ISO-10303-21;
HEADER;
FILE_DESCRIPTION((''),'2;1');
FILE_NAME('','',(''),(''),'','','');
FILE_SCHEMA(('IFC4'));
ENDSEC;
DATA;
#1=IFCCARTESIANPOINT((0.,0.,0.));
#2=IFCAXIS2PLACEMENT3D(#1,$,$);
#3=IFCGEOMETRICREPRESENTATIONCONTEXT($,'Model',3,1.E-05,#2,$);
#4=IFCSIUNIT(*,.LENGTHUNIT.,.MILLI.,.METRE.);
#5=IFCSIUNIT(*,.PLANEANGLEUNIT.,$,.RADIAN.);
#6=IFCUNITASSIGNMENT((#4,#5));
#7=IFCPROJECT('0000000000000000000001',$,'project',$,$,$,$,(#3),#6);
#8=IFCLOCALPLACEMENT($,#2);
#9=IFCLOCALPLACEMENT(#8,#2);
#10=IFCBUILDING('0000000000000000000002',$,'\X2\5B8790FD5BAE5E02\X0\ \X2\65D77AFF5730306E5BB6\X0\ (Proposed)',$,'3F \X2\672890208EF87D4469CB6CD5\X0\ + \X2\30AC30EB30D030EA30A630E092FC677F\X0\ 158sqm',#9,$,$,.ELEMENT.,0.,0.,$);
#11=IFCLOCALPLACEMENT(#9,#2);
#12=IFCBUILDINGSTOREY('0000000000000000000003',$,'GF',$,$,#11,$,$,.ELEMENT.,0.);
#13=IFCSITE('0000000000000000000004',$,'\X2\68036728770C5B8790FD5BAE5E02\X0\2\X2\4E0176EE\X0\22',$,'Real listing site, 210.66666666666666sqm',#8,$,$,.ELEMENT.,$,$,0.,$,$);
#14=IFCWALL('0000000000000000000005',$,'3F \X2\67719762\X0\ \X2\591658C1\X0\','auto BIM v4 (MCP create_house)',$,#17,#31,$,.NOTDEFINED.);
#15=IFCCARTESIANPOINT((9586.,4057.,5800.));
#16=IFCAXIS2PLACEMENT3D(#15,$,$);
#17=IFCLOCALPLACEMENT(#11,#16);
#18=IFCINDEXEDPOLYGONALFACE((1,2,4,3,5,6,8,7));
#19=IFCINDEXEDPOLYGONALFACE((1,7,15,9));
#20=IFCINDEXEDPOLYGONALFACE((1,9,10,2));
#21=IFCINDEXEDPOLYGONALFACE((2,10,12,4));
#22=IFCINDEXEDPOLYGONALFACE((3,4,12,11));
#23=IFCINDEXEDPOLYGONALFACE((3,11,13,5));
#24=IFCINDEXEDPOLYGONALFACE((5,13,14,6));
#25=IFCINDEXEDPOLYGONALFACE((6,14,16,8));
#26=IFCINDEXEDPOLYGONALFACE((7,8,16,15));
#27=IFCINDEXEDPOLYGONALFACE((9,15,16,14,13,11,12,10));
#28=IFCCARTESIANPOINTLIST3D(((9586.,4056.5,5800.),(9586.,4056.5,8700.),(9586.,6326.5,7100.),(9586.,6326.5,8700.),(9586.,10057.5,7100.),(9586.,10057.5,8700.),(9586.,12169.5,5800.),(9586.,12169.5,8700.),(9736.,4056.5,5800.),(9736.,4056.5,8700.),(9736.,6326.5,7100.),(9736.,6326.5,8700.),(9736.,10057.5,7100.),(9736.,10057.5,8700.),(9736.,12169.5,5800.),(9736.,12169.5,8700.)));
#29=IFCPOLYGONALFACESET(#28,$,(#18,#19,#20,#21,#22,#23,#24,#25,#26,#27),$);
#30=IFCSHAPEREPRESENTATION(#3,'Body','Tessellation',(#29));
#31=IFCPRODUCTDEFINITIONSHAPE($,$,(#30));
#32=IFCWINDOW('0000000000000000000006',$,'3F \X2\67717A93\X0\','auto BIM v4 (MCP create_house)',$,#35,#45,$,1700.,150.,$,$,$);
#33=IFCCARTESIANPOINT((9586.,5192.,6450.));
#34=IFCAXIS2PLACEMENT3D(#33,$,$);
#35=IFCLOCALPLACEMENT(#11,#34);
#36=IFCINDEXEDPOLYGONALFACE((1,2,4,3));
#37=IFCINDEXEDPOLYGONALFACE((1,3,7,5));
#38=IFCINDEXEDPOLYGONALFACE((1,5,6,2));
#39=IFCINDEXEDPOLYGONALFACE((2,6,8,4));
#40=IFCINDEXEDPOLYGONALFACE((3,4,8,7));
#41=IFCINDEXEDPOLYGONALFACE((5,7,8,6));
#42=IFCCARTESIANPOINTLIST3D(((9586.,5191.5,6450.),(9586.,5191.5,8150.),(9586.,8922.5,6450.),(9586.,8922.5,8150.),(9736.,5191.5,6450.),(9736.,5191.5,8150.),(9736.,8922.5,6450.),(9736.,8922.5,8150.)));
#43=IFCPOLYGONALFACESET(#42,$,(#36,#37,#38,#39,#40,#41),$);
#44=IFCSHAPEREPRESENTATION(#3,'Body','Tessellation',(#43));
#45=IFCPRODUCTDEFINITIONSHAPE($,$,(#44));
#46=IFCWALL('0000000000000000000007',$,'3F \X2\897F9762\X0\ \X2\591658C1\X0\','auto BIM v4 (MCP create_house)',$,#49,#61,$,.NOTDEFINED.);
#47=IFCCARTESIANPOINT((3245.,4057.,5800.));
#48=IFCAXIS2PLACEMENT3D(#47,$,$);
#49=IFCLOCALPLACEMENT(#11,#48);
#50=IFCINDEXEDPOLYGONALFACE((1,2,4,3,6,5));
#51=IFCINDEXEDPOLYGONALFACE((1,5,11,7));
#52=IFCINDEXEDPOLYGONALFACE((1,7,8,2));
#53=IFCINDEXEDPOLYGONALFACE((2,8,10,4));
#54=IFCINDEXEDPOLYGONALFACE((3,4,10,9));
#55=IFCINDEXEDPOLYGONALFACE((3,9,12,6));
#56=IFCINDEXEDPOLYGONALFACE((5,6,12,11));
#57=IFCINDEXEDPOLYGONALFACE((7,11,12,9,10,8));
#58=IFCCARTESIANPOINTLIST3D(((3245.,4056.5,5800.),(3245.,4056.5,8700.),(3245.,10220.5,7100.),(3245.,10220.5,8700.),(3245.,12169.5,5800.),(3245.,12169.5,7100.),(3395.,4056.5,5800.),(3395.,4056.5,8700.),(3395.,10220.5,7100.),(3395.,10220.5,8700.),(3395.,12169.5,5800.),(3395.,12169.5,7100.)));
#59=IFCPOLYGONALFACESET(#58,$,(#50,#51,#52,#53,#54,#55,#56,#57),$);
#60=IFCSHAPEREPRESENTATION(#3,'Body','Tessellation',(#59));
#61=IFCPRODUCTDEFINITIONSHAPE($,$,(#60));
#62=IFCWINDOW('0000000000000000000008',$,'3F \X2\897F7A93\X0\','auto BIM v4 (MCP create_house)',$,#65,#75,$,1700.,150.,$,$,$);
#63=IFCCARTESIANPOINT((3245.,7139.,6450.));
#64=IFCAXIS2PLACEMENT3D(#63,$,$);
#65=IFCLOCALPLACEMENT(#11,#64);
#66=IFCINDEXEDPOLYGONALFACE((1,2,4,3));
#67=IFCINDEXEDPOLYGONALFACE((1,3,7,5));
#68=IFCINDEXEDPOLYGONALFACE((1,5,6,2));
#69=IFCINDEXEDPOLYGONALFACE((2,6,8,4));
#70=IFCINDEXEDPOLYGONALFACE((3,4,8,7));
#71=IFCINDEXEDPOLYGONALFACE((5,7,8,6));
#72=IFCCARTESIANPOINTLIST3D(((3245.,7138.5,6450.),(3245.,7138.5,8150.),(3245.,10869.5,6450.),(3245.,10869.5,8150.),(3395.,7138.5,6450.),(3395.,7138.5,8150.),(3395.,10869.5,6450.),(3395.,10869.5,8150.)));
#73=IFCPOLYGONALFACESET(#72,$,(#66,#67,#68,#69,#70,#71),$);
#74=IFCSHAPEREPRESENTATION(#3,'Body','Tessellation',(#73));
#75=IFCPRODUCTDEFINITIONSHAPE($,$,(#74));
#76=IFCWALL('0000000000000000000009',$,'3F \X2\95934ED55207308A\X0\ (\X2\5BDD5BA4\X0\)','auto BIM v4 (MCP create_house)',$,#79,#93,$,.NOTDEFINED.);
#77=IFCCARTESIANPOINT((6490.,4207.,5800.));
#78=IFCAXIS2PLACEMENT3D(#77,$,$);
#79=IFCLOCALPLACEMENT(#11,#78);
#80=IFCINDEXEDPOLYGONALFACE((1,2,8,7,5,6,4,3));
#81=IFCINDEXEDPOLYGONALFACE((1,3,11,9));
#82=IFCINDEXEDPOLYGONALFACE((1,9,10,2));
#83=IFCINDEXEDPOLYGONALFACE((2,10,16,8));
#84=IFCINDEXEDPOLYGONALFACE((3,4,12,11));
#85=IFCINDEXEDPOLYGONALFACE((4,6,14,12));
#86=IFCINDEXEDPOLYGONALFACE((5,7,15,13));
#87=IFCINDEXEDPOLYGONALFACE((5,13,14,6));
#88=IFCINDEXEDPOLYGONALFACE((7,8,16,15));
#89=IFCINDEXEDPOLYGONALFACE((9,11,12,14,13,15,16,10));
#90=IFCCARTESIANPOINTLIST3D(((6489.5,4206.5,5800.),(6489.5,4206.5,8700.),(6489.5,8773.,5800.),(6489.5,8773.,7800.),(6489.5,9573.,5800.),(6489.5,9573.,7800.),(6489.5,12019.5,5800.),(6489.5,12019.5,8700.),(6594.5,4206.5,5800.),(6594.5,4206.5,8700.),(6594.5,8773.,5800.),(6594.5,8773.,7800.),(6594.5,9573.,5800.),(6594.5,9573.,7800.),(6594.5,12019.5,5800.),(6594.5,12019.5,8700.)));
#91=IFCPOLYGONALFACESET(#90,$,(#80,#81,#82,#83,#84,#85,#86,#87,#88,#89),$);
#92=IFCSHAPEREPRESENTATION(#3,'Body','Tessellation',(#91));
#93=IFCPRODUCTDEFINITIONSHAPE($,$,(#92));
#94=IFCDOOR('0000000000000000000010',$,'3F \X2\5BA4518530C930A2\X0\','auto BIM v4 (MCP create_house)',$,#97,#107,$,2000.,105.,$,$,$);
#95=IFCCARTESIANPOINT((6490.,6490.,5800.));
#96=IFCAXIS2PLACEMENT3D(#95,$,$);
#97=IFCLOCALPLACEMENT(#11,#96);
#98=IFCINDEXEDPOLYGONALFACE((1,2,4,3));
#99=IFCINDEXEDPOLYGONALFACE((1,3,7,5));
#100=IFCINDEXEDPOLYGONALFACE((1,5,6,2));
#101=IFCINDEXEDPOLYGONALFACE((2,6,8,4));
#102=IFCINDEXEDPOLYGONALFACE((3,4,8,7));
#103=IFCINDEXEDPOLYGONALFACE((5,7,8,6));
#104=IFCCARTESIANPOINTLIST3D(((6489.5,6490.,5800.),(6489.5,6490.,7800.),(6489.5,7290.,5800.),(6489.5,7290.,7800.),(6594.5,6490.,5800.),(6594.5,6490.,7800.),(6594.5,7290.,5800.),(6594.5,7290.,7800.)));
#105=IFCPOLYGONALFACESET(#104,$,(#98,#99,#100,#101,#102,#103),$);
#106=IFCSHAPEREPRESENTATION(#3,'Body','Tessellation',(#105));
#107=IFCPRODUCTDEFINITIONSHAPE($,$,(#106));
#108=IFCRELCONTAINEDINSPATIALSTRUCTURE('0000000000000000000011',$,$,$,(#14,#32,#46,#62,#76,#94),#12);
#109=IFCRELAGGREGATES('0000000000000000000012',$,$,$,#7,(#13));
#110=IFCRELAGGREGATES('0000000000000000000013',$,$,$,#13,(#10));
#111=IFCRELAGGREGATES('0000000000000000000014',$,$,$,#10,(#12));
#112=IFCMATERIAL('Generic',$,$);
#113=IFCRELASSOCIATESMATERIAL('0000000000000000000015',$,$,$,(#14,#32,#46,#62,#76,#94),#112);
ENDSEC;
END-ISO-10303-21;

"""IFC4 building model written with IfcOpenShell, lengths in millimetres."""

from ifc_helpers import new_model, si_unit, frame, frame_2d, origin, place, context, project, spatial, rectangle, extrude, material, element, fill, save


model = new_model("IFC4")

# Units and contexts
model_context = context("Model", 3, precision=1e-05, world=origin())
ifc_project = project(units=[si_unit("LENGTHUNIT", "METRE", prefix="MILLI"), si_unit("PLANEANGLEUNIT", "RADIAN")], contexts=[model_context])

# Site, building, storey
site_placement = place(None, origin())
site = spatial("IfcSite", under=ifc_project, at=site_placement, Name="栃木県宇都宮市2丁目22", ObjectType="Real listing site, 210.66666666666666sqm", CompositionType="ELEMENT", RefElevation=0.0)
building_placement = place(site_placement, origin())
building = spatial("IfcBuilding", under=site, at=building_placement, Name="宇都宮市 旗竿地の家 (Proposed)", ObjectType="3F 木造軸組構法 + ガルバリウム鋼板 158sqm", CompositionType="ELEMENT", ElevationOfRefHeight=0.0, ElevationOfTerrain=0.0)
storey_placement = place(building_placement, origin())
storey = spatial("IfcBuildingStorey", under=building, at=storey_placement, Name="GF", CompositionType="ELEMENT", Elevation=0.0)

# Shared definitions
ifc_material = material(Name="Generic")

# Walls, openings, windows
wall_1_placement = place(storey_placement, frame((9586.0, 4057.0, 5800.0)))
wall_1 = element("IfcWall", 1, at=wall_1_placement, inside=storey, material=ifc_material, Name="3F 東面 外壁", Description="auto BIM v4 (MCP create_house)", PredefinedType="NOTDEFINED", context=model_context, shape_type="SweptSolid", body=[
    extrude(rectangle(XDim=150.0, YDim=8113.0, at=frame_2d((75.0, 4056.0))), frame((9586.0, 4057.0, 5800.0)), (0.0, 0.0, 1.0), 2900.0),
])
opening_1_placement = place(storey_placement, frame((9586.0, 5192.0, 6450.0)))
opening_1 = element("IfcOpeningElement", 2, at=opening_1_placement, cuts=wall_1, PredefinedType="NOTDEFINED", context=model_context, shape_type="SweptSolid", body=[
    extrude(rectangle(XDim=150.0, YDim=3731.0, at=frame_2d((75.0, 1865.0))), frame((9586.0, 5192.0, 6450.0)), (0.0, 0.0, 1.0), 1700.0),
])
window_1_placement = place(storey_placement, frame((9586.0, 5192.0, 6450.0)))
window_1 = element("IfcWindow", 3, at=window_1_placement, inside=storey, material=ifc_material, Name="3F 東窓", Description="auto BIM v4 (MCP create_house)", OverallHeight=1700.0, OverallWidth=150.0, context=model_context, shape_type="SweptSolid", body=[
    extrude(rectangle(XDim=150.0, YDim=3731.0, at=frame_2d((75.0, 1865.0))), frame((9586.0, 5192.0, 6450.0)), (0.0, 0.0, 1.0), 1700.0),
])
fill(opening_1, window_1)
wall_2_placement = place(storey_placement, frame((3245.0, 4057.0, 5800.0)))
wall_2 = element("IfcWall", 4, at=wall_2_placement, inside=storey, material=ifc_material, Name="3F 西面 外壁", Description="auto BIM v4 (MCP create_house)", PredefinedType="NOTDEFINED", context=model_context, shape_type="SweptSolid", body=[
    extrude(rectangle(XDim=150.0, YDim=8113.0, at=frame_2d((75.0, 4056.0))), frame((3245.0, 4057.0, 5800.0)), (0.0, 0.0, 1.0), 2900.0),
])
opening_2_placement = place(storey_placement, frame((3245.0, 7139.0, 6450.0)))
opening_2 = element("IfcOpeningElement", 5, at=opening_2_placement, cuts=wall_2, PredefinedType="NOTDEFINED", context=model_context, shape_type="SweptSolid", body=[
    extrude(rectangle(XDim=150.0, YDim=3731.0, at=frame_2d((75.0, 1865.0))), frame((3245.0, 7139.0, 6450.0)), (0.0, 0.0, 1.0), 1700.0),
])
window_2_placement = place(storey_placement, frame((3245.0, 7139.0, 6450.0)))
window_2 = element("IfcWindow", 6, at=window_2_placement, inside=storey, material=ifc_material, Name="3F 西窓", Description="auto BIM v4 (MCP create_house)", OverallHeight=1700.0, OverallWidth=150.0, context=model_context, shape_type="SweptSolid", body=[
    extrude(rectangle(XDim=150.0, YDim=3731.0, at=frame_2d((75.0, 1865.0))), frame((3245.0, 7139.0, 6450.0)), (0.0, 0.0, 1.0), 1700.0),
])
fill(opening_2, window_2)

# Wall, opening, door
wall_3_placement = place(storey_placement, frame((6490.0, 4207.0, 5800.0)))
wall_3 = element("IfcWall", 7, at=wall_3_placement, inside=storey, material=ifc_material, Name="3F 間仕切り (寝室)", Description="auto BIM v4 (MCP create_house)", PredefinedType="NOTDEFINED", context=model_context, shape_type="SweptSolid", body=[
    extrude(rectangle(XDim=105.0, YDim=7813.0, at=frame_2d((52.0, 3906.0))), frame((6490.0, 4207.0, 5800.0)), (0.0, 0.0, 1.0), 2900.0),
])
opening_3_placement = place(storey_placement, frame((6490.0, 6490.0, 5800.0)))
opening_3 = element("IfcOpeningElement", 8, at=opening_3_placement, cuts=wall_3, PredefinedType="NOTDEFINED", context=model_context, shape_type="SweptSolid", body=[
    extrude(rectangle(XDim=105.0, YDim=800.0, at=frame_2d((52.0, 400.0))), frame((6490.0, 6490.0, 5800.0)), (0.0, 0.0, 1.0), 2000.0),
])
door_1_placement = place(storey_placement, frame((6490.0, 6490.0, 5800.0)))
door_1 = element("IfcDoor", 9, at=door_1_placement, inside=storey, material=ifc_material, Name="3F 室内ドア", Description="auto BIM v4 (MCP create_house)", OverallHeight=2000.0, OverallWidth=105.0, context=model_context, shape_type="SweptSolid", body=[
    extrude(rectangle(XDim=105.0, YDim=800.0, at=frame_2d((52.0, 400.0))), frame((6490.0, 6490.0, 5800.0)), (0.0, 0.0, 1.0), 2000.0),
])
fill(opening_3, door_1)

save(model, "model.ifc")
